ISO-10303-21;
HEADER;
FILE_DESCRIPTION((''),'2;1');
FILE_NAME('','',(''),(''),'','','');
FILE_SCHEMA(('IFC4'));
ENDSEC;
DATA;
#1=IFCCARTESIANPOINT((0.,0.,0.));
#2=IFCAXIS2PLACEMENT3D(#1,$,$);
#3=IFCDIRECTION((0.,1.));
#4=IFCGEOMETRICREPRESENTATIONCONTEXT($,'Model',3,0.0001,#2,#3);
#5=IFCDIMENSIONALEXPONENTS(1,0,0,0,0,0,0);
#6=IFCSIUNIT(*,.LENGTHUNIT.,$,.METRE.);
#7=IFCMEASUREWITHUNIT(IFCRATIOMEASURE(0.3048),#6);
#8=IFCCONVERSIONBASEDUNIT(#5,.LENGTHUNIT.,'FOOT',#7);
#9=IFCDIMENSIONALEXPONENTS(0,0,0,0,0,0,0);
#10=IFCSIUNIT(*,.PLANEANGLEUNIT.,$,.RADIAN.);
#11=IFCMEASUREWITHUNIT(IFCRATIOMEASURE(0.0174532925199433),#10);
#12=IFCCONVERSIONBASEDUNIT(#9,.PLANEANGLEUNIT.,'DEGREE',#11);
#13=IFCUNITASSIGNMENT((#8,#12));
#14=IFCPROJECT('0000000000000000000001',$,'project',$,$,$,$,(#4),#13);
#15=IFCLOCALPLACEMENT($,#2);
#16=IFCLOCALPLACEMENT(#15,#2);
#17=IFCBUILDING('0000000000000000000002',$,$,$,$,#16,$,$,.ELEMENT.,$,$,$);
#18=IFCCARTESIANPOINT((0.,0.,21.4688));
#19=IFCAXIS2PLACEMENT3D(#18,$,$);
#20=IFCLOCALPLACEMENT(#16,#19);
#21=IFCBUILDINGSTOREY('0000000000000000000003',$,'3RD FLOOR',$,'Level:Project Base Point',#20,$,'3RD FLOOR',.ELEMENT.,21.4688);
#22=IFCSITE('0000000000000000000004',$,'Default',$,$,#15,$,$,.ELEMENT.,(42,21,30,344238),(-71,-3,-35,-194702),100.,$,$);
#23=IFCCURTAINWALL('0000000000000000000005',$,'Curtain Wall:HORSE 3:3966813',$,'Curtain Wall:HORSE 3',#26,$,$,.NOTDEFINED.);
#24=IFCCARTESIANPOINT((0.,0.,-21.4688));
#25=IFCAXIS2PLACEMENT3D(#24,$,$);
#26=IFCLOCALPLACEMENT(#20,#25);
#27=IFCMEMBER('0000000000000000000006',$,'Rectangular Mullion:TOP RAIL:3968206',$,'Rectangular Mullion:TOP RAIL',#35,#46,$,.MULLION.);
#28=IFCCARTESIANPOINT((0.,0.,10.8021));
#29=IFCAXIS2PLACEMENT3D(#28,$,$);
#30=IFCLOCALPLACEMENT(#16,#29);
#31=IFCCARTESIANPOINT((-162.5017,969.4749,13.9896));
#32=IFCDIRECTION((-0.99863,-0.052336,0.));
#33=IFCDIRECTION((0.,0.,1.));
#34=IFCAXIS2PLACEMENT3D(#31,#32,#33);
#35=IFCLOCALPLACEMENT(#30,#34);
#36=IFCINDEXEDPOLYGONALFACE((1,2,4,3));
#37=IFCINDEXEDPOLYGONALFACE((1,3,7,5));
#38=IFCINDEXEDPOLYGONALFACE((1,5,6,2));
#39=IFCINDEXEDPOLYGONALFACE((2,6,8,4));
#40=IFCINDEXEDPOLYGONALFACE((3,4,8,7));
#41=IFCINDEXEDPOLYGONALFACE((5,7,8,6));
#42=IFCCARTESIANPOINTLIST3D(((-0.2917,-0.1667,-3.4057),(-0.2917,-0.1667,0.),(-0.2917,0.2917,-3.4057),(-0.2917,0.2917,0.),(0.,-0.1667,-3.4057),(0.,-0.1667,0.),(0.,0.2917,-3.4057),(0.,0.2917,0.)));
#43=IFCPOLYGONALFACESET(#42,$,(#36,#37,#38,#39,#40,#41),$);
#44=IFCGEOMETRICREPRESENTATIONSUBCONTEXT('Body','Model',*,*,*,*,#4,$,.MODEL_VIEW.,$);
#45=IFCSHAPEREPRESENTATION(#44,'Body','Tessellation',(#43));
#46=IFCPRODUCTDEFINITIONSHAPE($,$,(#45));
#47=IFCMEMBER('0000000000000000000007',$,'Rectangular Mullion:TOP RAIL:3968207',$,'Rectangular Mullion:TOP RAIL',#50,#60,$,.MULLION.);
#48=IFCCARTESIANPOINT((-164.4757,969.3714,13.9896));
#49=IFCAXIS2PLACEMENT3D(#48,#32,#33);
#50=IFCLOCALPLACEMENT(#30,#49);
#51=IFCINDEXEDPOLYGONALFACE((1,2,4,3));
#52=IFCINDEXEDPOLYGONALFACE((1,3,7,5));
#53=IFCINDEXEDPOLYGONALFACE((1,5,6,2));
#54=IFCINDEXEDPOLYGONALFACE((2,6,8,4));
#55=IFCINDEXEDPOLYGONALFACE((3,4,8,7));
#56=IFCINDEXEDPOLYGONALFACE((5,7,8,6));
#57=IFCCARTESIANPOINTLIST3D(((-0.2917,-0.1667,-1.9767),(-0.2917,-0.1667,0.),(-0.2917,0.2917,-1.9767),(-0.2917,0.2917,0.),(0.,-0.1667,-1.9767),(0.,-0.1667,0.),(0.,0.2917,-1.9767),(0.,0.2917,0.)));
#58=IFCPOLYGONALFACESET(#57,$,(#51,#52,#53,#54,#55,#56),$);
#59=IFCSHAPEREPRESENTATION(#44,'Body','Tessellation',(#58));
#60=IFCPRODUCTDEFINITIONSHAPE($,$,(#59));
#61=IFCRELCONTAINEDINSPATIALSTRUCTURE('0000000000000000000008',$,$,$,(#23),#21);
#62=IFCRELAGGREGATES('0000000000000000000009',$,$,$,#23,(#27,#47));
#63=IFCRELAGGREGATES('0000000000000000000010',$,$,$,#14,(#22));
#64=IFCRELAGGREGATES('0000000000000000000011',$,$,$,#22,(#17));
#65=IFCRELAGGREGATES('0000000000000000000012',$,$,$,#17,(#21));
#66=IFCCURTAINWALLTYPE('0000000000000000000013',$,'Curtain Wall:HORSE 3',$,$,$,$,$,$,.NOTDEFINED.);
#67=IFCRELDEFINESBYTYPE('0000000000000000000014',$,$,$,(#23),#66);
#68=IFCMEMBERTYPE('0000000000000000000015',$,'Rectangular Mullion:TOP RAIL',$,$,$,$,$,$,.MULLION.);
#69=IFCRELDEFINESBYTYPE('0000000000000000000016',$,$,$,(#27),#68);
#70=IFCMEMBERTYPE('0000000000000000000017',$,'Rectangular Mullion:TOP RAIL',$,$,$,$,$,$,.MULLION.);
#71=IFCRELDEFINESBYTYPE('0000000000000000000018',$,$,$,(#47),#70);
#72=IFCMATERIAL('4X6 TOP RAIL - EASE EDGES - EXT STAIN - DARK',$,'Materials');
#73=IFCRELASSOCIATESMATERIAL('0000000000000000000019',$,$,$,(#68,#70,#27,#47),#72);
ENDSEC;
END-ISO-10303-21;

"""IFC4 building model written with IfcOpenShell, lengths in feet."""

from ifc_helpers import new_model, entity, si_unit, converted_unit, direction, frame, origin, origin_2d_with_axis, place, context, subcontext, project, spatial, rectangle, extrude, source, transform, mapped, material, material_profile, profile_set, profile_usage, type_object, type_shapes, element, aggregate, save


model = new_model("IFC4")

# Units and contexts
model_context = context("Model", 3, precision=0.0001, world=origin(), true_north=direction((0.0, 1.0)))
body_context = subcontext(model_context, "Body", "Model", "MODEL_VIEW")
ifc_project = project(units=[converted_unit("LENGTHUNIT", "FOOT", entity("IfcRatioMeasure", 0.3048), si_unit("LENGTHUNIT", "METRE"), dimensions=[1, 0, 0, 0, 0, 0, 0]), converted_unit("PLANEANGLEUNIT", "DEGREE", entity("IfcRatioMeasure", 0.0174532925199433), si_unit("PLANEANGLEUNIT", "RADIAN"), dimensions=[0, 0, 0, 0, 0, 0, 0])], contexts=[model_context])

# Site, building, storey
site_placement = place(None, origin())
site = spatial("IfcSite", under=ifc_project, at=site_placement, Name="Default", CompositionType="ELEMENT", RefLatitude=(42, 21, 30, 344238), RefLongitude=(-71, -3, -35, -194702), RefElevation=100.0)
building_placement = place(site_placement, origin())
building = spatial("IfcBuilding", under=site, at=building_placement, CompositionType="ELEMENT")
storey_placement = place(building_placement, frame((0.0, 0.0, 21.4688)))
storey = spatial("IfcBuildingStorey", under=building, at=storey_placement, Name="3RD FLOOR", ObjectType="Level:Project Base Point", LongName="3RD FLOOR", CompositionType="ELEMENT", Elevation=21.4688)

# Curtain wall
curtain_wall_type_1 = type_object("IfcCurtainWallType", Name="Curtain Wall:HORSE 3", PredefinedType="NOTDEFINED")
curtain_wall_1_placement = place(storey_placement, frame((0.0, 0.0, -21.4688)))
curtain_wall_1 = element("IfcCurtainWall", 1, at=curtain_wall_1_placement, inside=storey, type_object=curtain_wall_type_1, Name="Curtain Wall:HORSE 3:3966813", ObjectType="Curtain Wall:HORSE 3", PredefinedType="NOTDEFINED")

# Members
ifc_material_1 = material(Name="4X6 TOP RAIL - EASE EDGES - EXT STAIN - DARK", Category="Materials")
ifc_material_profile_1 = material_profile(ifc_material_1, rectangle(XDim=0.4583, YDim=0.2917, at=origin_2d_with_axis()), Name="TOP RAIL")
ifc_profile_set_1 = profile_set([ifc_material_profile_1], Name="TOP RAIL")
ifc_profile_usage_1 = profile_usage(ifc_profile_set_1)
member_type_1 = type_object("IfcMemberType", Name="Rectangular Mullion:TOP RAIL", PredefinedType="MULLION", material=ifc_profile_set_1)
shared_shape_1 = source(origin(), body_context, "Body", "SweptSolid", [
    extrude(rectangle(XDim=0.4583, YDim=0.2917, at=origin_2d_with_axis()), frame((-0.1458, 0.0625, -3.4057), z_axis=(0.0, 0.0, 1.0), x_axis=(0.0, -1.0, 0.0)), (0.0, 0.0, 1.0), 3.4057),
])
type_shapes(member_type_1, [shared_shape_1])
placement = place(building_placement, frame((0.0, 0.0, 10.8021)))
member_1_placement = place(placement, frame((-162.5017, 969.4749, 13.9896), z_axis=(-0.99863, -0.052336, 0.0), x_axis=(0.0, 0.0, 1.0)))
member_1 = element("IfcMember", 2, at=member_1_placement, type_object=member_type_1, material=ifc_profile_usage_1, Name="Rectangular Mullion:TOP RAIL:3968206", ObjectType="Rectangular Mullion:TOP RAIL", PredefinedType="MULLION", context=body_context, shape_type="MappedRepresentation", body=[
    mapped(shared_shape_1, transform((0.0, 0.0, 0.0), scale=1.0)),
])
ifc_profile_usage_2 = profile_usage(ifc_profile_set_1)
member_type_2 = type_object("IfcMemberType", Name="Rectangular Mullion:TOP RAIL", PredefinedType="MULLION", material=ifc_profile_set_1)
shared_shape_2 = source(origin(), body_context, "Body", "SweptSolid", [
    extrude(rectangle(XDim=0.4583, YDim=0.2917, at=origin_2d_with_axis()), frame((-0.1458, 0.0625, -1.9767), z_axis=(0.0, 0.0, 1.0), x_axis=(0.0, -1.0, 0.0)), (0.0, 0.0, 1.0), 1.9767),
])
type_shapes(member_type_2, [shared_shape_2])
member_2_placement = place(placement, frame((-164.4757, 969.3714, 13.9896), z_axis=(-0.99863, -0.052336, 0.0), x_axis=(0.0, 0.0, 1.0)))
member_2 = element("IfcMember", 3, at=member_2_placement, type_object=member_type_2, material=ifc_profile_usage_2, Name="Rectangular Mullion:TOP RAIL:3968207", ObjectType="Rectangular Mullion:TOP RAIL", PredefinedType="MULLION", context=body_context, shape_type="MappedRepresentation", body=[
    mapped(shared_shape_2, transform((0.0, 0.0, 0.0), scale=1.0)),
])

aggregate(curtain_wall_1, [member_1, member_2])

save(model, "model.ifc")
